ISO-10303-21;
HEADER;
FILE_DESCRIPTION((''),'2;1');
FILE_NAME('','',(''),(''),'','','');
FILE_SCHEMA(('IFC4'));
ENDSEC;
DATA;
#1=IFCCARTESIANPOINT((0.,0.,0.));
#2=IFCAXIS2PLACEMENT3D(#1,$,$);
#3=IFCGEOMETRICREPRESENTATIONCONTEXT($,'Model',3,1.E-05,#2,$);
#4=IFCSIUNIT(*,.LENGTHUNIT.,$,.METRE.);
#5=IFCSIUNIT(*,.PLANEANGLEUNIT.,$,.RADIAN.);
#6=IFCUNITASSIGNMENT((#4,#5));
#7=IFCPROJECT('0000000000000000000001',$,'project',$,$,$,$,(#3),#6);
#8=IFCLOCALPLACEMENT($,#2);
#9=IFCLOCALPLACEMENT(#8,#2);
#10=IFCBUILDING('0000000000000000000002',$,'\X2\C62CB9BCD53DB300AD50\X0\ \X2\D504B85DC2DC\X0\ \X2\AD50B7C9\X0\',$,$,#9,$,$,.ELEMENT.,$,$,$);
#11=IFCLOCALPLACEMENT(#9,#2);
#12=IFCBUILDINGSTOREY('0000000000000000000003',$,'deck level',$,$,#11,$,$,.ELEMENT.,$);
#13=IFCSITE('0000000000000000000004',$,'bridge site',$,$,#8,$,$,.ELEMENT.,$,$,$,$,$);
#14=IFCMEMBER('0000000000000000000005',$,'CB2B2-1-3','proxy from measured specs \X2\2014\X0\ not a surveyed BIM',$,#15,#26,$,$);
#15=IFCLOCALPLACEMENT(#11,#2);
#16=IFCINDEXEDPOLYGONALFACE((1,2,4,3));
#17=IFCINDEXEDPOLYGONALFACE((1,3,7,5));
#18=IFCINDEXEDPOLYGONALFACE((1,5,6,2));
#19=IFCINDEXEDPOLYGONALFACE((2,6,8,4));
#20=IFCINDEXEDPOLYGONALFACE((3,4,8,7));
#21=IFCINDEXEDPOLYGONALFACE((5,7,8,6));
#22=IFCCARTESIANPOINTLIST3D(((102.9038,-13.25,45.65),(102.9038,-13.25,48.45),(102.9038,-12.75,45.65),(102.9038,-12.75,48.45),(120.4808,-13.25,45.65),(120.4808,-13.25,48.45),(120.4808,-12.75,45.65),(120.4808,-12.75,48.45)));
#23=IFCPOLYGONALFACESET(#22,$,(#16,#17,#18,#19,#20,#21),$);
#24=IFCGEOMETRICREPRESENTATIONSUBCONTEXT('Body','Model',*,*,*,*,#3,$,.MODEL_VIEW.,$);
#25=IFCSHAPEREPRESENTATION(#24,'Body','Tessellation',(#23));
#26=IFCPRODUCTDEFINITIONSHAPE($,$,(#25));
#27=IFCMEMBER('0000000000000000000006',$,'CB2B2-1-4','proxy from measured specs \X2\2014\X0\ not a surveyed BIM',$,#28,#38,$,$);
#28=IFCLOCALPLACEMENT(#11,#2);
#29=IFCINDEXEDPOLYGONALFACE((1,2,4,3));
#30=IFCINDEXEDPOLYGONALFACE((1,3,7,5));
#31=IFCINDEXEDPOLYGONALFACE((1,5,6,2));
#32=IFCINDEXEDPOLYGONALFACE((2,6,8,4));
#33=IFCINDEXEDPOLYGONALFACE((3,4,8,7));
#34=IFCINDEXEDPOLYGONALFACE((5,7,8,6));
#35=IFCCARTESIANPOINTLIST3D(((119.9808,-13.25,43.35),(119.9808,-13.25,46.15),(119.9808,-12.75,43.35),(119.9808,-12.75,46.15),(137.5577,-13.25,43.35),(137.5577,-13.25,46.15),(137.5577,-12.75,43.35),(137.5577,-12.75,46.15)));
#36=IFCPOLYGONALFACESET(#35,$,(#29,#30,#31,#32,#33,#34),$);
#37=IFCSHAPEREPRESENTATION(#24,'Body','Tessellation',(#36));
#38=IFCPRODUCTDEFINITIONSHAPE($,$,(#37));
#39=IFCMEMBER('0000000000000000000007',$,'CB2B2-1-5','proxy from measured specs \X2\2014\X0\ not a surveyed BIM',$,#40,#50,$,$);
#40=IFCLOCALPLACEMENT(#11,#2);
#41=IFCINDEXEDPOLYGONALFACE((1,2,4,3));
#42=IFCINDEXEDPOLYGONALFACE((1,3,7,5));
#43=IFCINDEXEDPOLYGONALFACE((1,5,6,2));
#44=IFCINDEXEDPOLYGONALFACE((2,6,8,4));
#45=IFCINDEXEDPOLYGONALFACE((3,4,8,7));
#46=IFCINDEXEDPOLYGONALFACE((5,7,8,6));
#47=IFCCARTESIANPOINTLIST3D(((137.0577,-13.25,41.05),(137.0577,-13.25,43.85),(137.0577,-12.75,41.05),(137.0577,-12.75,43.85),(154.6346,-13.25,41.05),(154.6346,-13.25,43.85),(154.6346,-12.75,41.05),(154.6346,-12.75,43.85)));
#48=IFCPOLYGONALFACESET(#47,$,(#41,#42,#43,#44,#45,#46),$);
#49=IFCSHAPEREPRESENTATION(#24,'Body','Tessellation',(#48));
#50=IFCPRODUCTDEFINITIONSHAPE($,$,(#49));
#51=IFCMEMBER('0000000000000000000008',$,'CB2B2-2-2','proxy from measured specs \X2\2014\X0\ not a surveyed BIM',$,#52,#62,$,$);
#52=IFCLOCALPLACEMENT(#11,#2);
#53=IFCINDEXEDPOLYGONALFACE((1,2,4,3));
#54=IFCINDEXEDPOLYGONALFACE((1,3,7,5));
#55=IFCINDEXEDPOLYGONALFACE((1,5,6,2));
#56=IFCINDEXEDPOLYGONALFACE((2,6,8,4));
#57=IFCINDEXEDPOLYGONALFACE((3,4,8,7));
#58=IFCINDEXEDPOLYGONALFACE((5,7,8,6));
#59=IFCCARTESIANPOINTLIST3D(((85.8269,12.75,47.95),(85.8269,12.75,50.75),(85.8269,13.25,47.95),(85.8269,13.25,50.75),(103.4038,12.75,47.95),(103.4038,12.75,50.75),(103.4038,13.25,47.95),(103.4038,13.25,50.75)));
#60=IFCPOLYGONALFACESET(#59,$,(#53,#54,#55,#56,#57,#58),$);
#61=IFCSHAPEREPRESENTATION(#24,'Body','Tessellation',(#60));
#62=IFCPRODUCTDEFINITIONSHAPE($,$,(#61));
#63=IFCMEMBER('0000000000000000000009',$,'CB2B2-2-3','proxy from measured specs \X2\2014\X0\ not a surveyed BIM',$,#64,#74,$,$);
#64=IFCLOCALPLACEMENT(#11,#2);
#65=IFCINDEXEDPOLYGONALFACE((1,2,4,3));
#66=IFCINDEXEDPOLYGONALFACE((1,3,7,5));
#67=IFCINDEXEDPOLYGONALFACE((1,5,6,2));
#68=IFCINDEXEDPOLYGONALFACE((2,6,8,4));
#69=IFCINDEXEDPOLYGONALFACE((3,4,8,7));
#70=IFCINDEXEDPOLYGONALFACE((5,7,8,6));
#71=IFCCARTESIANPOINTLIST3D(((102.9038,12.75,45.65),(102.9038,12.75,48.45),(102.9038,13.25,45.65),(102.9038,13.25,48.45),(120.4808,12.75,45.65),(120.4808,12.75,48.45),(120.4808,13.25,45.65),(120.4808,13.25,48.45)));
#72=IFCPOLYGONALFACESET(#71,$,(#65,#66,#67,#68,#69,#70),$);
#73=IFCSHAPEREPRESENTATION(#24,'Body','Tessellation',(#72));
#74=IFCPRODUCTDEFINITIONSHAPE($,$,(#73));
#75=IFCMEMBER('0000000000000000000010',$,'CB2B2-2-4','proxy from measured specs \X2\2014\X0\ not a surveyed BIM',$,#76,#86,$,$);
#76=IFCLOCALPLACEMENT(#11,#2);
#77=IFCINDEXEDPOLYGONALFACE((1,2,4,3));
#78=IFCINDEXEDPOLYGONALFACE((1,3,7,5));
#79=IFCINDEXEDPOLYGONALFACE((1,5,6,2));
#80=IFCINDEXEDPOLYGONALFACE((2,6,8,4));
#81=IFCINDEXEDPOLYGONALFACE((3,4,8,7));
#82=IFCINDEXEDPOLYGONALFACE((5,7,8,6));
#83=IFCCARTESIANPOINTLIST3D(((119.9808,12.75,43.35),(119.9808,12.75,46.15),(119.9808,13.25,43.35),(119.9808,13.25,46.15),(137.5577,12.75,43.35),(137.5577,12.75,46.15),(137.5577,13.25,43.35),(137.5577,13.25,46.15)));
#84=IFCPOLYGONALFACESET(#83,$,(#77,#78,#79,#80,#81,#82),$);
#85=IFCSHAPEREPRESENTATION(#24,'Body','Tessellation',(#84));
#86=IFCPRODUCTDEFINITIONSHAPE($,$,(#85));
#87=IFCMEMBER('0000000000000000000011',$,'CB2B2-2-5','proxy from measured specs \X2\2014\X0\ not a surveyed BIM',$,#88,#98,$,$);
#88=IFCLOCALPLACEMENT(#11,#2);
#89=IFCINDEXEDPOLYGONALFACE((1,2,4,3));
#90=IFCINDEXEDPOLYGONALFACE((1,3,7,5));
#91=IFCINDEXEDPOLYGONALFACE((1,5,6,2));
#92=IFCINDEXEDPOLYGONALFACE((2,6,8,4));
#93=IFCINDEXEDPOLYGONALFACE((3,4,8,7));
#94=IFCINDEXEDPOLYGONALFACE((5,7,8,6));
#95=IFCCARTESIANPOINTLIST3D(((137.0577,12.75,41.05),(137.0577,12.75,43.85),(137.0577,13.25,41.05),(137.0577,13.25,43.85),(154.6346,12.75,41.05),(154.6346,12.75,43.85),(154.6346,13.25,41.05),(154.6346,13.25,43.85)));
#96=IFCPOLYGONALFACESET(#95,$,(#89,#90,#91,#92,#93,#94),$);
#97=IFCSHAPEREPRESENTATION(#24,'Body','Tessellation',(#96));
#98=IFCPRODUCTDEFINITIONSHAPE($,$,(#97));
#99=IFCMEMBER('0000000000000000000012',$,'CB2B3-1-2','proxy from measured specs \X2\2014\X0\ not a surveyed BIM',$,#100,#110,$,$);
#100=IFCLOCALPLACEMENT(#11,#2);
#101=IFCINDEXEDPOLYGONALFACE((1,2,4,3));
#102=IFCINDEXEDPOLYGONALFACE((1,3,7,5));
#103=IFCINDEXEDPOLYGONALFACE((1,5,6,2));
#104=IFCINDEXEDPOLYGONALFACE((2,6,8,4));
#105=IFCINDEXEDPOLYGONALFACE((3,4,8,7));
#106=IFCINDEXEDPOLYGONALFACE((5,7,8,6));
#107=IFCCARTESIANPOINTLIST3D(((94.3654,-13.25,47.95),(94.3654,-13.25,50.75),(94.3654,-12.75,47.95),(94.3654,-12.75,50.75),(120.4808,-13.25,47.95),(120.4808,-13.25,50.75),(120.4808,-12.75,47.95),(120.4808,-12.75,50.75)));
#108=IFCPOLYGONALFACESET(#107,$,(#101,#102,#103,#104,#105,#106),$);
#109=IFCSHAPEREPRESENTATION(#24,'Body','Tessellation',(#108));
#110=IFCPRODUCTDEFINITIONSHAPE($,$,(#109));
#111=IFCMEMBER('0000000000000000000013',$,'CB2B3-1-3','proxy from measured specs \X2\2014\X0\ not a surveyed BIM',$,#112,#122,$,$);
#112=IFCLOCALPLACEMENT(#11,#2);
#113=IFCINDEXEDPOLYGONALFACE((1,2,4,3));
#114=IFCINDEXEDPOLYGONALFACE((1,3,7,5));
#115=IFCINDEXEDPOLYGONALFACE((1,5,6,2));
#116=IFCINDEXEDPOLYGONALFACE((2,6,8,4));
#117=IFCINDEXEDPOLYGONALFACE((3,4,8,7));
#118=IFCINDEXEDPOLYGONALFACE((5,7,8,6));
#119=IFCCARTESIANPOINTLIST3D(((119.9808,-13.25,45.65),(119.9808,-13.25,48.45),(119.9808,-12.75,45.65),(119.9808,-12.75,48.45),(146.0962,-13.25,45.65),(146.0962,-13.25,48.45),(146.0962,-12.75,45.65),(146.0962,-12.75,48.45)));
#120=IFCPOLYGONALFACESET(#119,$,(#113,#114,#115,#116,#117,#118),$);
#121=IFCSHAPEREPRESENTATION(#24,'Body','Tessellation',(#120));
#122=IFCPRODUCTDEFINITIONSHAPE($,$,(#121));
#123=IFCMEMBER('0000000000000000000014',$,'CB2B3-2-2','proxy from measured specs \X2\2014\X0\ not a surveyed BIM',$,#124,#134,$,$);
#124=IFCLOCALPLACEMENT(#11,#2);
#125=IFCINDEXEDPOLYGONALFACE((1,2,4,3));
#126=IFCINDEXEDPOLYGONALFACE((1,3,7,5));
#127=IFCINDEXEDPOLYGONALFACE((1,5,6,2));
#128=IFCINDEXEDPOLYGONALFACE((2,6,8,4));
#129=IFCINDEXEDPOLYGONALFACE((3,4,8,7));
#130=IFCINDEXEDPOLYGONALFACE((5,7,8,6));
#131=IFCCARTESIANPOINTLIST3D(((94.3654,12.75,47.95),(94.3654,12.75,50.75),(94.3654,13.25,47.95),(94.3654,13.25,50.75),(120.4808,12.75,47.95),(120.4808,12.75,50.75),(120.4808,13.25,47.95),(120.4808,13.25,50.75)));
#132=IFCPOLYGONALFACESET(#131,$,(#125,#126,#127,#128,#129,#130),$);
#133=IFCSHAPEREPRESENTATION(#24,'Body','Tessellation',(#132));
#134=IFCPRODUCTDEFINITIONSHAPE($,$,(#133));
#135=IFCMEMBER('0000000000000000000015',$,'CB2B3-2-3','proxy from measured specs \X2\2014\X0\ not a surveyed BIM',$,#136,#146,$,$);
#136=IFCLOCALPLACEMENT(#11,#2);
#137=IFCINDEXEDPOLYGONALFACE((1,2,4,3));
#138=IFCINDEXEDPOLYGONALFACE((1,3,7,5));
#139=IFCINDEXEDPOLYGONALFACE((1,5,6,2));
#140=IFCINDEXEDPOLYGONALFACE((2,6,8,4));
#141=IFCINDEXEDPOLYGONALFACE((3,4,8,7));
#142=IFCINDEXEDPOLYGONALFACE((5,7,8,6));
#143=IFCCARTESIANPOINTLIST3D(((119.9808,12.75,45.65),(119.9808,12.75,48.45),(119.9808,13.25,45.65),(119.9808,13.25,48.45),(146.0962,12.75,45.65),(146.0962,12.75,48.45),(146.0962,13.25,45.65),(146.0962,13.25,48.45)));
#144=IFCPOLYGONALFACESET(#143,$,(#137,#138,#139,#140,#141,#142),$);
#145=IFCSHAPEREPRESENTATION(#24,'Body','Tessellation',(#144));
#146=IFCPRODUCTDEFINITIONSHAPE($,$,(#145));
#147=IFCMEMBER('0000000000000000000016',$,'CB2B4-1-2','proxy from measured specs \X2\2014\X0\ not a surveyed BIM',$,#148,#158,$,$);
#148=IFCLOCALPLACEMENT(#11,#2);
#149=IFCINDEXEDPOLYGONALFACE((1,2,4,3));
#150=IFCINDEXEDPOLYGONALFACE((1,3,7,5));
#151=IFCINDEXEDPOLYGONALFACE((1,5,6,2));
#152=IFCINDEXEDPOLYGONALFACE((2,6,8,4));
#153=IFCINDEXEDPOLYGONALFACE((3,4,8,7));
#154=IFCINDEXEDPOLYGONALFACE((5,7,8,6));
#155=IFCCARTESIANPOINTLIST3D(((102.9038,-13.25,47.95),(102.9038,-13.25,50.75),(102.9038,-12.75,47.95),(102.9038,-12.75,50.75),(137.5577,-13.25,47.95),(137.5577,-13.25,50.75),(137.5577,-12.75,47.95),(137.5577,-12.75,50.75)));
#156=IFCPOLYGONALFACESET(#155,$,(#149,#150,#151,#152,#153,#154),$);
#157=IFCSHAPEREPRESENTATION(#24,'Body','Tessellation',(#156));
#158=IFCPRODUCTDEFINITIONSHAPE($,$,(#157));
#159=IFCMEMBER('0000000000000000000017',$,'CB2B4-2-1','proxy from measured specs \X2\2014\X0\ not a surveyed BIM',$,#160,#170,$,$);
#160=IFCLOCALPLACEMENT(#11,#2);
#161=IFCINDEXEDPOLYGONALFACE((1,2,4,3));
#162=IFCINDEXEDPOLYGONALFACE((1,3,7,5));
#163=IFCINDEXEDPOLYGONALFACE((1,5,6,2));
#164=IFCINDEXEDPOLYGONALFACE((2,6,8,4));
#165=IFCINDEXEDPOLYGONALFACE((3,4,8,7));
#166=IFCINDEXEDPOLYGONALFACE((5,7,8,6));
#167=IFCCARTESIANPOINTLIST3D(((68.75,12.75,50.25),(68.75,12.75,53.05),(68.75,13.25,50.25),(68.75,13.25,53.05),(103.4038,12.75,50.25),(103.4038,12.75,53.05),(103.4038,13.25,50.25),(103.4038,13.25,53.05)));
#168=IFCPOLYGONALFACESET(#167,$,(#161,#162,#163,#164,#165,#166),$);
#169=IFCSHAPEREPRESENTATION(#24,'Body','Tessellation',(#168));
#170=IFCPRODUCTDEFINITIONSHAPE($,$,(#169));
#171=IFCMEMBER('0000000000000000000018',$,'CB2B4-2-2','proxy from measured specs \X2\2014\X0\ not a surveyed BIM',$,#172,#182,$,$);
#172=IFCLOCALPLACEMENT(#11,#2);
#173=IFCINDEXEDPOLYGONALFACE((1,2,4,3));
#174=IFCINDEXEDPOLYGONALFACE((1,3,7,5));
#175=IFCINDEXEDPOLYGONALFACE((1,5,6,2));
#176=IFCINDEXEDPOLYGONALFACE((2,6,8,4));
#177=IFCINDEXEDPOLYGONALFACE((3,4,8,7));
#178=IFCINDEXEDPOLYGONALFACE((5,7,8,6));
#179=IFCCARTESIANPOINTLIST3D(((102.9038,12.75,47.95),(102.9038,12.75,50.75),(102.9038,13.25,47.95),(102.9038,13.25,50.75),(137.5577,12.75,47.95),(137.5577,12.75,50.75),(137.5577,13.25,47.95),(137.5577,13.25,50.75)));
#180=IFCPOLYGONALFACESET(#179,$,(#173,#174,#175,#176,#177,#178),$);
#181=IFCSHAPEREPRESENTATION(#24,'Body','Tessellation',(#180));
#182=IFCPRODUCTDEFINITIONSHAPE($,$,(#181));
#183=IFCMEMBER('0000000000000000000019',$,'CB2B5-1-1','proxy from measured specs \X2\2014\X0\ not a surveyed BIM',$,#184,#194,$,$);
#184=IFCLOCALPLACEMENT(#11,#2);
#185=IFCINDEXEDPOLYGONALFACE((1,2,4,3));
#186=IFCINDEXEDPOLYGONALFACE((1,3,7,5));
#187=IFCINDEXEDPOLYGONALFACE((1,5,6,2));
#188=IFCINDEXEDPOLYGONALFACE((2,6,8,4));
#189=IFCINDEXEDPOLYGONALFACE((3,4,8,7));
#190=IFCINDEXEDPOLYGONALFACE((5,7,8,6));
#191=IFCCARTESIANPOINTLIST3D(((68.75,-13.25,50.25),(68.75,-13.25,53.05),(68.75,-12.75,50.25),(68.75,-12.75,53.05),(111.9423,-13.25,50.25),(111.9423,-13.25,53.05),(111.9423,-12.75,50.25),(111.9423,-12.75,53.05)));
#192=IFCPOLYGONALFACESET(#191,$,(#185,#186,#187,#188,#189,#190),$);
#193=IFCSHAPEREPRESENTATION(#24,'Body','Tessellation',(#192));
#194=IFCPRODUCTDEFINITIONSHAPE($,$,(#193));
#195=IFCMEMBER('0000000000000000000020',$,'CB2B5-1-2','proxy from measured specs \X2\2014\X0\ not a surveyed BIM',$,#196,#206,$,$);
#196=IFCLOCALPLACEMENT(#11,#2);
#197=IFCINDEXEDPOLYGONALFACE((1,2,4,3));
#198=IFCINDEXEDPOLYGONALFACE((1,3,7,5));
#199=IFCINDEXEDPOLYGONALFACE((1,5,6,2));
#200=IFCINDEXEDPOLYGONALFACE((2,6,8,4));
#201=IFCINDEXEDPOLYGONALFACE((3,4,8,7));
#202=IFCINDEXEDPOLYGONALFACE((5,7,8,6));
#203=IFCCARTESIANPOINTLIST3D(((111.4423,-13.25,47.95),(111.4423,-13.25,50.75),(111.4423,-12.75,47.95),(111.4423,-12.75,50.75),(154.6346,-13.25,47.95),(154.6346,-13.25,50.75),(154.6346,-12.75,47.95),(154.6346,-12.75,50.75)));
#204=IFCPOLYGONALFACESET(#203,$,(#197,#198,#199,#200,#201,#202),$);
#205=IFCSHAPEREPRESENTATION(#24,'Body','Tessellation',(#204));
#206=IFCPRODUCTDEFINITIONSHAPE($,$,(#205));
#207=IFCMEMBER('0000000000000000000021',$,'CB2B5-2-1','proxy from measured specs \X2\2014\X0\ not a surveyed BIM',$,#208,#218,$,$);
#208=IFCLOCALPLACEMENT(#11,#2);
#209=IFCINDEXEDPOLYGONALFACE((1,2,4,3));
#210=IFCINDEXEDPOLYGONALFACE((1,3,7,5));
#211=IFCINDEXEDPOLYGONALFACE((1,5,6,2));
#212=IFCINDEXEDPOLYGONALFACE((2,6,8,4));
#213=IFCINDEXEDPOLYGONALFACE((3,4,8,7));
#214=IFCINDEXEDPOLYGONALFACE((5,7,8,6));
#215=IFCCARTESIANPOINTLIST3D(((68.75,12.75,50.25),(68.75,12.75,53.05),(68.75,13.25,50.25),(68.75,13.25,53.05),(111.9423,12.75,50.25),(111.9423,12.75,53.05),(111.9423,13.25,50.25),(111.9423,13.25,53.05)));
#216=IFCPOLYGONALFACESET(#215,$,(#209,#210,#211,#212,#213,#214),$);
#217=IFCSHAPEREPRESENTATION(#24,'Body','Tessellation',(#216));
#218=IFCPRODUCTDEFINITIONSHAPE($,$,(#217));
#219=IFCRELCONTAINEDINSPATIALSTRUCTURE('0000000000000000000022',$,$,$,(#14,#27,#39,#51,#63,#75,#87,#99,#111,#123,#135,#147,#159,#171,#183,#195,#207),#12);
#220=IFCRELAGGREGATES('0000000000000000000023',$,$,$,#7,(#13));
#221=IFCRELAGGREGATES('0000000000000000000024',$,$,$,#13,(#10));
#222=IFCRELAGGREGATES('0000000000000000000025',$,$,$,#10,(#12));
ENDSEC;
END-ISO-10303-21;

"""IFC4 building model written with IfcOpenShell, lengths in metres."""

from ifc_helpers import new_model, si_unit, frame, origin, origin_2d, place, context, subcontext, project, spatial, rectangle, extrude, element, save


model = new_model("IFC4")

# Units and contexts
model_context = context("Model", 3, precision=1e-05, world=origin())
body_context = subcontext(model_context, "Body", "Model", "MODEL_VIEW")
ifc_project = project(units=[si_unit("LENGTHUNIT", "METRE"), si_unit("PLANEANGLEUNIT", "RADIAN")], contexts=[model_context])

# Site, building, storey
site_placement = place(None, origin())
site = spatial("IfcSite", under=ifc_project, at=site_placement, Name="bridge site", CompositionType="ELEMENT")
building_placement = place(site_placement, origin())
building = spatial("IfcBuilding", under=site, at=building_placement, Name="올림픽대교 프록시 교량", CompositionType="ELEMENT")
storey_placement = place(building_placement, origin())
storey = spatial("IfcBuildingStorey", under=building, at=storey_placement, Name="deck level", CompositionType="ELEMENT")

# Members
member_1_placement = place(storey_placement, frame((111.6923, -13.0, 45.65)))
element("IfcMember", 1, at=member_1_placement, inside=storey, Name="CB2B2-1-3", Description="proxy from measured specs — not a surveyed BIM", context=body_context, shape_type="SweptSolid", body=[
    extrude(rectangle(XDim=17.5769, YDim=0.5, at=origin_2d()), origin(), (0.0, 0.0, 1.0), 2.8),
])
member_2_placement = place(storey_placement, frame((128.7692, -13.0, 43.35)))
element("IfcMember", 2, at=member_2_placement, inside=storey, Name="CB2B2-1-4", Description="proxy from measured specs — not a surveyed BIM", context=body_context, shape_type="SweptSolid", body=[
    extrude(rectangle(XDim=17.5769, YDim=0.5, at=origin_2d()), origin(), (0.0, 0.0, 1.0), 2.8),
])
member_3_placement = place(storey_placement, frame((145.8462, -13.0, 41.05)))
element("IfcMember", 3, at=member_3_placement, inside=storey, Name="CB2B2-1-5", Description="proxy from measured specs — not a surveyed BIM", context=body_context, shape_type="SweptSolid", body=[
    extrude(rectangle(XDim=17.5769, YDim=0.5, at=origin_2d()), origin(), (0.0, 0.0, 1.0), 2.8),
])
member_4_placement = place(storey_placement, frame((94.6154, 13.0, 47.95)))
element("IfcMember", 4, at=member_4_placement, inside=storey, Name="CB2B2-2-2", Description="proxy from measured specs — not a surveyed BIM", context=body_context, shape_type="SweptSolid", body=[
    extrude(rectangle(XDim=17.5769, YDim=0.5, at=origin_2d()), origin(), (0.0, 0.0, 1.0), 2.8),
])
member_5_placement = place(storey_placement, frame((111.6923, 13.0, 45.65)))
element("IfcMember", 5, at=member_5_placement, inside=storey, Name="CB2B2-2-3", Description="proxy from measured specs — not a surveyed BIM", context=body_context, shape_type="SweptSolid", body=[
    extrude(rectangle(XDim=17.5769, YDim=0.5, at=origin_2d()), origin(), (0.0, 0.0, 1.0), 2.8),
])
member_6_placement = place(storey_placement, frame((128.7692, 13.0, 43.35)))
element("IfcMember", 6, at=member_6_placement, inside=storey, Name="CB2B2-2-4", Description="proxy from measured specs — not a surveyed BIM", context=body_context, shape_type="SweptSolid", body=[
    extrude(rectangle(XDim=17.5769, YDim=0.5, at=origin_2d()), origin(), (0.0, 0.0, 1.0), 2.8),
])
member_7_placement = place(storey_placement, frame((145.8462, 13.0, 41.05)))
element("IfcMember", 7, at=member_7_placement, inside=storey, Name="CB2B2-2-5", Description="proxy from measured specs — not a surveyed BIM", context=body_context, shape_type="SweptSolid", body=[
    extrude(rectangle(XDim=17.5769, YDim=0.5, at=origin_2d()), origin(), (0.0, 0.0, 1.0), 2.8),
])
member_8_placement = place(storey_placement, frame((107.4231, -13.0, 47.95)))
element("IfcMember", 8, at=member_8_placement, inside=storey, Name="CB2B3-1-2", Description="proxy from measured specs — not a surveyed BIM", context=body_context, shape_type="SweptSolid", body=[
    extrude(rectangle(XDim=26.1154, YDim=0.5, at=origin_2d()), origin(), (0.0, 0.0, 1.0), 2.8),
])
member_9_placement = place(storey_placement, frame((133.0385, -13.0, 45.65)))
element("IfcMember", 9, at=member_9_placement, inside=storey, Name="CB2B3-1-3", Description="proxy from measured specs — not a surveyed BIM", context=body_context, shape_type="SweptSolid", body=[
    extrude(rectangle(XDim=26.1154, YDim=0.5, at=origin_2d()), origin(), (0.0, 0.0, 1.0), 2.8),
])
member_10_placement = place(storey_placement, frame((107.4231, 13.0, 47.95)))
element("IfcMember", 10, at=member_10_placement, inside=storey, Name="CB2B3-2-2", Description="proxy from measured specs — not a surveyed BIM", context=body_context, shape_type="SweptSolid", body=[
    extrude(rectangle(XDim=26.1154, YDim=0.5, at=origin_2d()), origin(), (0.0, 0.0, 1.0), 2.8),
])
member_11_placement = place(storey_placement, frame((133.0385, 13.0, 45.65)))
element("IfcMember", 11, at=member_11_placement, inside=storey, Name="CB2B3-2-3", Description="proxy from measured specs — not a surveyed BIM", context=body_context, shape_type="SweptSolid", body=[
    extrude(rectangle(XDim=26.1154, YDim=0.5, at=origin_2d()), origin(), (0.0, 0.0, 1.0), 2.8),
])
member_12_placement = place(storey_placement, frame((120.2308, -13.0, 47.95)))
element("IfcMember", 12, at=member_12_placement, inside=storey, Name="CB2B4-1-2", Description="proxy from measured specs — not a surveyed BIM", context=body_context, shape_type="SweptSolid", body=[
    extrude(rectangle(XDim=34.6538, YDim=0.5, at=origin_2d()), origin(), (0.0, 0.0, 1.0), 2.8),
])
member_13_placement = place(storey_placement, frame((86.0769, 13.0, 50.25)))
element("IfcMember", 13, at=member_13_placement, inside=storey, Name="CB2B4-2-1", Description="proxy from measured specs — not a surveyed BIM", context=body_context, shape_type="SweptSolid", body=[
    extrude(rectangle(XDim=34.6538, YDim=0.5, at=origin_2d()), origin(), (0.0, 0.0, 1.0), 2.8),
])
member_14_placement = place(storey_placement, frame((120.2308, 13.0, 47.95)))
element("IfcMember", 14, at=member_14_placement, inside=storey, Name="CB2B4-2-2", Description="proxy from measured specs — not a surveyed BIM", context=body_context, shape_type="SweptSolid", body=[
    extrude(rectangle(XDim=34.6538, YDim=0.5, at=origin_2d()), origin(), (0.0, 0.0, 1.0), 2.8),
])
member_15_placement = place(storey_placement, frame((90.3462, -13.0, 50.25)))
element("IfcMember", 15, at=member_15_placement, inside=storey, Name="CB2B5-1-1", Description="proxy from measured specs — not a surveyed BIM", context=body_context, shape_type="SweptSolid", body=[
    extrude(rectangle(XDim=43.1923, YDim=0.5, at=origin_2d()), origin(), (0.0, 0.0, 1.0), 2.8),
])
member_16_placement = place(storey_placement, frame((133.0385, -13.0, 47.95)))
element("IfcMember", 16, at=member_16_placement, inside=storey, Name="CB2B5-1-2", Description="proxy from measured specs — not a surveyed BIM", context=body_context, shape_type="SweptSolid", body=[
    extrude(rectangle(XDim=43.1923, YDim=0.5, at=origin_2d()), origin(), (0.0, 0.0, 1.0), 2.8),
])
member_17_placement = place(storey_placement, frame((90.3462, 13.0, 50.25)))
element("IfcMember", 17, at=member_17_placement, inside=storey, Name="CB2B5-2-1", Description="proxy from measured specs — not a surveyed BIM", context=body_context, shape_type="SweptSolid", body=[
    extrude(rectangle(XDim=43.1923, YDim=0.5, at=origin_2d()), origin(), (0.0, 0.0, 1.0), 2.8),
])

save(model, "model.ifc")
